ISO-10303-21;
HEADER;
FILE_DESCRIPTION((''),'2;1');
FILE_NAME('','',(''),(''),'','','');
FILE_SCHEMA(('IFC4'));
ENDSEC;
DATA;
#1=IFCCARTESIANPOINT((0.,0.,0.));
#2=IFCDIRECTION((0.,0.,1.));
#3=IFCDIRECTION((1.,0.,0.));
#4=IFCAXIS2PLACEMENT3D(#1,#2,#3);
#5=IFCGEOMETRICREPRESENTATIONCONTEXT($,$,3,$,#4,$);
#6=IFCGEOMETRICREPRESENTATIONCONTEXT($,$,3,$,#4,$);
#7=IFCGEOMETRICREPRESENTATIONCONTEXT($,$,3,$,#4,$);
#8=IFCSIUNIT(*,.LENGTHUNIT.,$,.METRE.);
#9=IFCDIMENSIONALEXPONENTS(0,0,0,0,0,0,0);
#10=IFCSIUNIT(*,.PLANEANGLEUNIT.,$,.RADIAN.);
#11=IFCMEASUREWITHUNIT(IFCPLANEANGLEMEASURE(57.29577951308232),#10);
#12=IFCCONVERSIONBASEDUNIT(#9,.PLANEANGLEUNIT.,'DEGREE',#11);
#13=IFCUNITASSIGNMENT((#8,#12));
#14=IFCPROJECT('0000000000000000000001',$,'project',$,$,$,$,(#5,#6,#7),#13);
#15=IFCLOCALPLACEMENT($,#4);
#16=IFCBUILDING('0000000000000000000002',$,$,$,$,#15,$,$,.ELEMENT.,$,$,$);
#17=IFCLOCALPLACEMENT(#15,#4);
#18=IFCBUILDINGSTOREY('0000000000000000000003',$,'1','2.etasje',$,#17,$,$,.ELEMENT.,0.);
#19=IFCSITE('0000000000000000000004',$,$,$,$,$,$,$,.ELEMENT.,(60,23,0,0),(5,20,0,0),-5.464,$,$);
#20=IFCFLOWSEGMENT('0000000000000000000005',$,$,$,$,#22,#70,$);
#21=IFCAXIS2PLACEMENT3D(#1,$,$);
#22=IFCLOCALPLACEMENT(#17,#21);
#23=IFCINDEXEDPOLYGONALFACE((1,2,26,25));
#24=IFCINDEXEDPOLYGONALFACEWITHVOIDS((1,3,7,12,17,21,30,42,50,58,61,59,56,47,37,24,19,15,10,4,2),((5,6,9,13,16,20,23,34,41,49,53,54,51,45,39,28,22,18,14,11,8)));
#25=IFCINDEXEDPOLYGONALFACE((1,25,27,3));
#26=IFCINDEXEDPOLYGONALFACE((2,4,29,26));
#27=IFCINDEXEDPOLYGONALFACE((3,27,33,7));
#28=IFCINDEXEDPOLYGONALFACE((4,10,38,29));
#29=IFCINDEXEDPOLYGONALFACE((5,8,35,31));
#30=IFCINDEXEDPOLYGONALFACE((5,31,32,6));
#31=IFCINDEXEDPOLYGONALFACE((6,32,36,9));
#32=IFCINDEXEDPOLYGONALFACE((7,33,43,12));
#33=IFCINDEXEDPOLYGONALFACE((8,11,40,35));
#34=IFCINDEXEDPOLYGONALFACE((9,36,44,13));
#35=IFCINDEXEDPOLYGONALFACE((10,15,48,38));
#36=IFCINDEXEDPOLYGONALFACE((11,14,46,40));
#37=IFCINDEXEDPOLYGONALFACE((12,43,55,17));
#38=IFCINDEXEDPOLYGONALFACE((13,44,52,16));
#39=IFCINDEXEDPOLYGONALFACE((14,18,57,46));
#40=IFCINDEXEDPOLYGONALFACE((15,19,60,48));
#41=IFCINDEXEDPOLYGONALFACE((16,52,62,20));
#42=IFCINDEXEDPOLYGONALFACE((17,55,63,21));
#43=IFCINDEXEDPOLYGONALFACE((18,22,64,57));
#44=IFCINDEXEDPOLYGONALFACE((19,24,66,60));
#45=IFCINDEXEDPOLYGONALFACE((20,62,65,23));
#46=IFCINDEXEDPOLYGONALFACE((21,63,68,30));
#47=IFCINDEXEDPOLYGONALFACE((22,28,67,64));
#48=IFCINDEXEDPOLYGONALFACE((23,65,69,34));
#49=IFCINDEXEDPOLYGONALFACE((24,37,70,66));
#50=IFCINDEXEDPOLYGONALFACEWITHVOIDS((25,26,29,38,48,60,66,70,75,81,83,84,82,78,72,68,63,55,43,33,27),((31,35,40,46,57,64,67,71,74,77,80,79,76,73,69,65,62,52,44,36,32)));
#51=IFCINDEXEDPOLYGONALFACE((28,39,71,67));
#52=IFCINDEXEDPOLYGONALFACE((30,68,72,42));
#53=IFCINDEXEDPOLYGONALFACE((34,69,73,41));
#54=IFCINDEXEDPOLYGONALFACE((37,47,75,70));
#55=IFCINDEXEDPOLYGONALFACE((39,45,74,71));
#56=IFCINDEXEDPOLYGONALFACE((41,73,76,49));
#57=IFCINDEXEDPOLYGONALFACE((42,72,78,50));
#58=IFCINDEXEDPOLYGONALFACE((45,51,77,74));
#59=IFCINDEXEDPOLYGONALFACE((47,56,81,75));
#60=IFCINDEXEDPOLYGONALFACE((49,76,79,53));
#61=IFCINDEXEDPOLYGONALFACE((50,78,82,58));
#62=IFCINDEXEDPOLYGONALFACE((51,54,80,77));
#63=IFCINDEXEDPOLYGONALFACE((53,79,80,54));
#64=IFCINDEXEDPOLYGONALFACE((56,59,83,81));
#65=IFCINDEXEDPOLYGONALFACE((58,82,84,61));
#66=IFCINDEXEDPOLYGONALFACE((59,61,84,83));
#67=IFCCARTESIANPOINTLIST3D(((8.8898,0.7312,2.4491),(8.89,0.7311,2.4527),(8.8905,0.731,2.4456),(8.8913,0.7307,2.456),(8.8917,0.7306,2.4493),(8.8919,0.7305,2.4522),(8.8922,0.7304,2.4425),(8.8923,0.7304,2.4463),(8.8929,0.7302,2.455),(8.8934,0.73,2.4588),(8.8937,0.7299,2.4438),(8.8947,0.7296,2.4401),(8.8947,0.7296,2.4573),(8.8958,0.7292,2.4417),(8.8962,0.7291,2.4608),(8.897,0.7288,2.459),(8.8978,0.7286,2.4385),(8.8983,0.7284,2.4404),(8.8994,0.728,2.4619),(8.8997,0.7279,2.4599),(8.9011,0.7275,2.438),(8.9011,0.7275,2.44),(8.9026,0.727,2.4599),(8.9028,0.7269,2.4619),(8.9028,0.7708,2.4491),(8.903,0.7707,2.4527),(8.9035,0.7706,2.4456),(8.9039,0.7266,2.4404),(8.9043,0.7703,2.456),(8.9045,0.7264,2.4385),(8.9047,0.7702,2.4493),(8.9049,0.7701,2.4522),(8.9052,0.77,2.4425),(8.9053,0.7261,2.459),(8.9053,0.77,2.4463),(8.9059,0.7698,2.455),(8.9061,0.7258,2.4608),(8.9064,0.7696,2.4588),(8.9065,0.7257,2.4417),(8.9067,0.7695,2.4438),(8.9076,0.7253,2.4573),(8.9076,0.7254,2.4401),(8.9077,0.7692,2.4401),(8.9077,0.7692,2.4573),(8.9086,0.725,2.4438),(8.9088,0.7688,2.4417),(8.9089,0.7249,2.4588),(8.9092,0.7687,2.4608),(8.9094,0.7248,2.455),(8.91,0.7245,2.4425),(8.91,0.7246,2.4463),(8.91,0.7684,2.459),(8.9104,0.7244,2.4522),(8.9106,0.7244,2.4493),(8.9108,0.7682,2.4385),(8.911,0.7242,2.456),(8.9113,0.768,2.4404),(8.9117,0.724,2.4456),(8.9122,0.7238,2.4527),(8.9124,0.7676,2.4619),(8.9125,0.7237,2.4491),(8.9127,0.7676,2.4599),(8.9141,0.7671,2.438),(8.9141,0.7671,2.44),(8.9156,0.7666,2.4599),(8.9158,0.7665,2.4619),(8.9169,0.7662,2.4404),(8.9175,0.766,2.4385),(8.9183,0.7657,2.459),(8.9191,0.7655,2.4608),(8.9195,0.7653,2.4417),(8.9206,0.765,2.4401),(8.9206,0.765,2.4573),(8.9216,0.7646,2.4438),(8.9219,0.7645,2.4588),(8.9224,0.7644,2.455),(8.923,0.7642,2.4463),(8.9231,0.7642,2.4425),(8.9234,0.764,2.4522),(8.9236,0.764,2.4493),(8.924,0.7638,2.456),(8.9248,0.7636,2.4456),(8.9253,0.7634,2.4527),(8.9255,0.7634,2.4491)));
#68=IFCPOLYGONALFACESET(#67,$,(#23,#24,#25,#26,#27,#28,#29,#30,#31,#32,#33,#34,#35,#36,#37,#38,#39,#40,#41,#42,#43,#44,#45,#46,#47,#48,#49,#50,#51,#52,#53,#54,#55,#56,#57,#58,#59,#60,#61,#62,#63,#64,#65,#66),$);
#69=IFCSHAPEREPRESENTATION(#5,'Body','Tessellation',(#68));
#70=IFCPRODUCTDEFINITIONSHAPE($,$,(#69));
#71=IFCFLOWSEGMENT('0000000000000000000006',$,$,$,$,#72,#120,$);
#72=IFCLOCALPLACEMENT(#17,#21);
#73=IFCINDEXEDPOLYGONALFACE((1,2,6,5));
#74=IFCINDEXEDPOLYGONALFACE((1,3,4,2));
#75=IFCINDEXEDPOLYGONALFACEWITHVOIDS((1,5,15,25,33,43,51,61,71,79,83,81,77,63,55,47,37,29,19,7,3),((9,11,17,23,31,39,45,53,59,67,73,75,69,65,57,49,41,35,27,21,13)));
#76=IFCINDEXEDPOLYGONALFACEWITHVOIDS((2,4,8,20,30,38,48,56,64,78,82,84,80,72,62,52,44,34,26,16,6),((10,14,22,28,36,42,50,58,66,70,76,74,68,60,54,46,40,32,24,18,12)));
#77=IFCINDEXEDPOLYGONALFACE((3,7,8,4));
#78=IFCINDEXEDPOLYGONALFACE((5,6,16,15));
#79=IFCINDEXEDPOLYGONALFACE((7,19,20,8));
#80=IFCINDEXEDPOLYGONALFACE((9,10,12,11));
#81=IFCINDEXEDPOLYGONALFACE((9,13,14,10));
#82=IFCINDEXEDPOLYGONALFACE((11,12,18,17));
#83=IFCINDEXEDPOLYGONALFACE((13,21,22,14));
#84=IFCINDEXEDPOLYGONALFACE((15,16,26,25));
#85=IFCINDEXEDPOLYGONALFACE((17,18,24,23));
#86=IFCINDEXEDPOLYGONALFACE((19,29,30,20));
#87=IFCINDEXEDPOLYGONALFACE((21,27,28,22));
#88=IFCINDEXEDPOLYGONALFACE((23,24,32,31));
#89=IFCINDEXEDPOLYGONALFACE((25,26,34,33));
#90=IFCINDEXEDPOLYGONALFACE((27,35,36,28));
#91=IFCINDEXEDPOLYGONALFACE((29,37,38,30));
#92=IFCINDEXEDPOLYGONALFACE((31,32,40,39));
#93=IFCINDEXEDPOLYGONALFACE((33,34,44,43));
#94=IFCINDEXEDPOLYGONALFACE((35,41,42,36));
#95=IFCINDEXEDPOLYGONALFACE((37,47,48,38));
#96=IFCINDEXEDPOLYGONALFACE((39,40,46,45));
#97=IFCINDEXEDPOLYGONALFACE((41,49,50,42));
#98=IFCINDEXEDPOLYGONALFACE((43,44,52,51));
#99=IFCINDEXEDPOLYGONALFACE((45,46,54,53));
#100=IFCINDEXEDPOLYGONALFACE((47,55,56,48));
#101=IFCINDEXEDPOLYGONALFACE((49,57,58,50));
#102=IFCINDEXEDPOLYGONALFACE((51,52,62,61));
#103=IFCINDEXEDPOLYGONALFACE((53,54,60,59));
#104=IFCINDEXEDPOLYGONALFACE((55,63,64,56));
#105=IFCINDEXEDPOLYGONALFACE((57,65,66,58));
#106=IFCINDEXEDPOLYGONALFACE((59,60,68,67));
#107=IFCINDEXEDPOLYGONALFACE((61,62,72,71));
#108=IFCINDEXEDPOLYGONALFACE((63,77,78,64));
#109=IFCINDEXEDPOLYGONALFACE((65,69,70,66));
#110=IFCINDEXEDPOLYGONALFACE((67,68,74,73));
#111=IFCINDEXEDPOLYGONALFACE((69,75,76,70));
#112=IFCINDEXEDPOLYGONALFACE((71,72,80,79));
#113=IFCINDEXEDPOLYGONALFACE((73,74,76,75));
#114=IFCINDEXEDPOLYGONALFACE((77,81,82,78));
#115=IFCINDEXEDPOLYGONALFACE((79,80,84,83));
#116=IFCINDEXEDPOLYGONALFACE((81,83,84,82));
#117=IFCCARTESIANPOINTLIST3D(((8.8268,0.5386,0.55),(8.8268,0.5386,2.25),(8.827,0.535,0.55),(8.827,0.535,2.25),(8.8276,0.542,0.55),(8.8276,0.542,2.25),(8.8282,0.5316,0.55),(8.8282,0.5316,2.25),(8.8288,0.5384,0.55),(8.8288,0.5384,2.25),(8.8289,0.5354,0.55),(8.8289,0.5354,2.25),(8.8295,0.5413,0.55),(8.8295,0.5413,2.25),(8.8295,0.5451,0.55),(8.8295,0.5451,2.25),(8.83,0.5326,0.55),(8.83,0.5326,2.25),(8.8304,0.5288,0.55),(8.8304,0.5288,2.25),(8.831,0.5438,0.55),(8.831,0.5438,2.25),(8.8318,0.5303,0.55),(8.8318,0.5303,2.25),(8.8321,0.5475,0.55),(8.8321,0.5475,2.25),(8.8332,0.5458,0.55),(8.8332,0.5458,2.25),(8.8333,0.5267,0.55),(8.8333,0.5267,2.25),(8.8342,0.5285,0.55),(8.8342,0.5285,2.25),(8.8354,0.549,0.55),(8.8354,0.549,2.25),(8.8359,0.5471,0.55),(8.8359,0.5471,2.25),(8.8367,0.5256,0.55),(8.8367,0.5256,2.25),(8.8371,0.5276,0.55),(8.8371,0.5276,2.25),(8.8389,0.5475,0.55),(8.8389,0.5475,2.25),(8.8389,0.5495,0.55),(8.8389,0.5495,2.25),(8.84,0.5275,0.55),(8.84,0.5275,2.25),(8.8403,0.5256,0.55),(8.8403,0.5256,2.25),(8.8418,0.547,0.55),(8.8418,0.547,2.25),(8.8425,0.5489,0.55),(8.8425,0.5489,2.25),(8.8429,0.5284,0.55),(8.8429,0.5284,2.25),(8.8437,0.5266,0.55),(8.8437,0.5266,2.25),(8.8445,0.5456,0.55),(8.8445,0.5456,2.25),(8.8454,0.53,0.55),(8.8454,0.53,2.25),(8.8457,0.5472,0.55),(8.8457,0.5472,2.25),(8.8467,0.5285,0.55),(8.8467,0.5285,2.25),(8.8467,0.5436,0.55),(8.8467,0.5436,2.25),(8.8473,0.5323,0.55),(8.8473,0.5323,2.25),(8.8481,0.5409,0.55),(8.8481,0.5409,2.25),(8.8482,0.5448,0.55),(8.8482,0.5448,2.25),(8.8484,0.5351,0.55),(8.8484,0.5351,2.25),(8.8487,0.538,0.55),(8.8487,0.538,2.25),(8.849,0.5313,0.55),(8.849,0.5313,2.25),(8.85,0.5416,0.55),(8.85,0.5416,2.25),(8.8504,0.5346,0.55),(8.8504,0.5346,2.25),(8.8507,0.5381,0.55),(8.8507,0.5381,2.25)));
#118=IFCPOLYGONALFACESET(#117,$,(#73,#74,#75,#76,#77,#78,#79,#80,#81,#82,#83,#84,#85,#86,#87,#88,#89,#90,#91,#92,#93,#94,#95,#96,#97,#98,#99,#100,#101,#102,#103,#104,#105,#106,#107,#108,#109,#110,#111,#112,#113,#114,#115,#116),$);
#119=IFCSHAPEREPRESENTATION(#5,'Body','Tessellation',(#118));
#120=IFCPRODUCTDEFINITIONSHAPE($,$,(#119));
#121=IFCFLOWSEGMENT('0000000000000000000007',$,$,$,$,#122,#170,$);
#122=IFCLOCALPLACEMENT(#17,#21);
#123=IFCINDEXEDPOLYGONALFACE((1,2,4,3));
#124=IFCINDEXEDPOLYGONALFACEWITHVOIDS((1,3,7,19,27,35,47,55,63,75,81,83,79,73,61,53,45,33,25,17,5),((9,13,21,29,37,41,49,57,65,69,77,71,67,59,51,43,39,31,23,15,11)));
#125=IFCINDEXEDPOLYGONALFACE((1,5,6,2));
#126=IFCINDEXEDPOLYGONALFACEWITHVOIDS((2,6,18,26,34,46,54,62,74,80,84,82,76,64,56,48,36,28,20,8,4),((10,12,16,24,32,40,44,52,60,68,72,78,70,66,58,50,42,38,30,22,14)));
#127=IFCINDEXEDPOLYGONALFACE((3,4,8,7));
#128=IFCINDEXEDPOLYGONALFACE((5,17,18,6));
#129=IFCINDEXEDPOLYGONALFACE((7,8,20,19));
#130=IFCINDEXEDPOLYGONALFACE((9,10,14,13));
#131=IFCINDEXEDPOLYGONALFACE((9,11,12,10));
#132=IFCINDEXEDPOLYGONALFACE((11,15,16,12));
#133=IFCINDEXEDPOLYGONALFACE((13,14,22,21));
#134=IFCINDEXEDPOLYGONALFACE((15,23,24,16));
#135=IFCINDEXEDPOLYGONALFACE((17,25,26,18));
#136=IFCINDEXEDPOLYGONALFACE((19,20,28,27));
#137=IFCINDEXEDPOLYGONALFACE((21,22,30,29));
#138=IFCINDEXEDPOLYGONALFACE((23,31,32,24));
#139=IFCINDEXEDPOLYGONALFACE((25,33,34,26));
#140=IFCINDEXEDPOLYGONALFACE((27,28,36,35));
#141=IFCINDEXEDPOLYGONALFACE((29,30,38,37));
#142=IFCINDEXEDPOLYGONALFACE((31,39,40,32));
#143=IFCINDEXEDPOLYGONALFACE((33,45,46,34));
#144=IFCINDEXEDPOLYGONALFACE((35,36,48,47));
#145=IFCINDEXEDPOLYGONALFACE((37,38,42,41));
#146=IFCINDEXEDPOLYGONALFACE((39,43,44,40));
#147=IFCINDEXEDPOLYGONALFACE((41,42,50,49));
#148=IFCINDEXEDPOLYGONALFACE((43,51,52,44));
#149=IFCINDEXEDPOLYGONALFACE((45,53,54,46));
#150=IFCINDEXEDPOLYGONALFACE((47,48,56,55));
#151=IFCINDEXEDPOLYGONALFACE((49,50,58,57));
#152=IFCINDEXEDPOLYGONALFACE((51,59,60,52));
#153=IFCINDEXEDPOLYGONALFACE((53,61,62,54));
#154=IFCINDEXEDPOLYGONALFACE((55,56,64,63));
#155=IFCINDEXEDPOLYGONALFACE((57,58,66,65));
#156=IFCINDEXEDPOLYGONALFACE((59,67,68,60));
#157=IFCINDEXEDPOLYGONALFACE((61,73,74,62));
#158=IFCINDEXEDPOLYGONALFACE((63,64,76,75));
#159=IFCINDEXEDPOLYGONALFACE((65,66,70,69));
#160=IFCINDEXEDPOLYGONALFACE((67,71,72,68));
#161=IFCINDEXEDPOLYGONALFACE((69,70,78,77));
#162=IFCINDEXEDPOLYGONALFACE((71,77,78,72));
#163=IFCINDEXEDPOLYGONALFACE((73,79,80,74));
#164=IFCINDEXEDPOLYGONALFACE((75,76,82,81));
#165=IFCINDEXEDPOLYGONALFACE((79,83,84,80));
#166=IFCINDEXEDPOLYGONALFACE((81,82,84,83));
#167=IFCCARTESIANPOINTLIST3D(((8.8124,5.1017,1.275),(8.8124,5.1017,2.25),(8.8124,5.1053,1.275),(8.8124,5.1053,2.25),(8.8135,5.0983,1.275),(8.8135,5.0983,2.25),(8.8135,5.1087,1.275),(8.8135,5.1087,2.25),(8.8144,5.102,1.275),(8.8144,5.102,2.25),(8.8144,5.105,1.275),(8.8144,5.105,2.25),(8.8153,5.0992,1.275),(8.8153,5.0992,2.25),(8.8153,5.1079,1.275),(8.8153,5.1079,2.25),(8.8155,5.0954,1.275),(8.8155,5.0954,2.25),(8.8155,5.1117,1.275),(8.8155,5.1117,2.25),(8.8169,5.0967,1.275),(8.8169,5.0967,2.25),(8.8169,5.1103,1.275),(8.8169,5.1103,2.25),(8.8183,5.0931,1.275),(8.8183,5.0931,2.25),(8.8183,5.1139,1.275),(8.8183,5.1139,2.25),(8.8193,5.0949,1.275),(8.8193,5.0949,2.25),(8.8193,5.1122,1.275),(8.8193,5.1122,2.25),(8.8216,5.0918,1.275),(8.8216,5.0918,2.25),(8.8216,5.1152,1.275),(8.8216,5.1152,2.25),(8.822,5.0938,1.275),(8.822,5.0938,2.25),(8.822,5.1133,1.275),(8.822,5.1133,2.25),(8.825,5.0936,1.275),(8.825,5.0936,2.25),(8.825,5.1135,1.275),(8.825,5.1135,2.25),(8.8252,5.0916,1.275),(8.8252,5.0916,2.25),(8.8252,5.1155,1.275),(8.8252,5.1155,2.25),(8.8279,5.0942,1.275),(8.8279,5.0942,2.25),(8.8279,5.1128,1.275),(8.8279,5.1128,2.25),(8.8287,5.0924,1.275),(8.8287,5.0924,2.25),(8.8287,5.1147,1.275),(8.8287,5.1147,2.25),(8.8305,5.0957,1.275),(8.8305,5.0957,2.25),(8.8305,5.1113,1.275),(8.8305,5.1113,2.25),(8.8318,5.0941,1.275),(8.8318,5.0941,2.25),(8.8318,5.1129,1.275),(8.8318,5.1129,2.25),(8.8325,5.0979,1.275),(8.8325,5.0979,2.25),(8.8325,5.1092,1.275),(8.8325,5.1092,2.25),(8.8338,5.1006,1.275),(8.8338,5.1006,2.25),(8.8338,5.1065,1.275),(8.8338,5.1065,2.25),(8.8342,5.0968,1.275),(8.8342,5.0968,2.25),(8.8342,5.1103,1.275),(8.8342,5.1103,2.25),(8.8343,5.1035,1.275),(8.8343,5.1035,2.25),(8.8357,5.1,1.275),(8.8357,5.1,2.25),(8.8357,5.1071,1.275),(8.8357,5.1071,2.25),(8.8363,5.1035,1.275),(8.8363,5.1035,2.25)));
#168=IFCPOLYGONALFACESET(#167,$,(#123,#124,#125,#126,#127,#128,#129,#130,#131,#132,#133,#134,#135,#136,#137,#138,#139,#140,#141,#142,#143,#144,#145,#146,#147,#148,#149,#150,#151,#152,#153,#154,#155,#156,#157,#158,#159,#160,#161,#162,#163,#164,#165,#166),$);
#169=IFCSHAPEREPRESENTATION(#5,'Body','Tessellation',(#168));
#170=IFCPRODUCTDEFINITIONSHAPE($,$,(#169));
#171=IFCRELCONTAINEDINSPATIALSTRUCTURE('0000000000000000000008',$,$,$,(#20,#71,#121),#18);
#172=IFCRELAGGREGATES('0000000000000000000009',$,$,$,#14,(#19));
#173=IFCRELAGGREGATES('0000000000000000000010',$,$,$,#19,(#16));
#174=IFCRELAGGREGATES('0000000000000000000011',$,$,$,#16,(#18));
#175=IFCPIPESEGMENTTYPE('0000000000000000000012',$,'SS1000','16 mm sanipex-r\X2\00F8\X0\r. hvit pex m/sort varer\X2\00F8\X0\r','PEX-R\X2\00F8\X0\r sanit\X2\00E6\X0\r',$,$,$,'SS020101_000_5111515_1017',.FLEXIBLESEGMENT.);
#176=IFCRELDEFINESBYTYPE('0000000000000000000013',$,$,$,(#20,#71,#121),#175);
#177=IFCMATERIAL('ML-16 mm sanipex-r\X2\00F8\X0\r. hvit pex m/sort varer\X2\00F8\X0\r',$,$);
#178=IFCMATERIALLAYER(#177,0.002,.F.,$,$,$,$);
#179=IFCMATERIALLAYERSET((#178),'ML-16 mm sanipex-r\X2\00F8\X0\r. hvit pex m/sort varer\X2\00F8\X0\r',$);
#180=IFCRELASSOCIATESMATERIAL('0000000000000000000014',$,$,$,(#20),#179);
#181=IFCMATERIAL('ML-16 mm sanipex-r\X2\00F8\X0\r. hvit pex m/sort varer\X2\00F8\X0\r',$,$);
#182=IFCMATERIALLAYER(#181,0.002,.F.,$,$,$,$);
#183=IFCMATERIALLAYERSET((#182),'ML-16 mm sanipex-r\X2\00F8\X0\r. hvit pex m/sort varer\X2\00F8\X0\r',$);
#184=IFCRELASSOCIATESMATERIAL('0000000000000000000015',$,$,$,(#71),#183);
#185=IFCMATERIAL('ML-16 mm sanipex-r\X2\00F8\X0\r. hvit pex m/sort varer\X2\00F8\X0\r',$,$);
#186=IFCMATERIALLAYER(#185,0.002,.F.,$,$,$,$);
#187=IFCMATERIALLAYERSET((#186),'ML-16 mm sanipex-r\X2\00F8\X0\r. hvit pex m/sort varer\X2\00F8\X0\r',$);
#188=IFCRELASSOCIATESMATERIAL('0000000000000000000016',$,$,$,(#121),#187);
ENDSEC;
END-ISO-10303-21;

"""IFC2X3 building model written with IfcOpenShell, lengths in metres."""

from ifc_helpers import new_model, entity, si_unit, converted_unit, frame, origin_with_axes, origin_2d_with_axis, place, context, project, spatial, hollow_circle, extrude, material, layer, layer_set, layer_usage, type_object, element, save


model = new_model("IFC2X3")

# Units and contexts
context_of_model_1 = context(None, 3, world=origin_with_axes())
context_of_model_2 = context(None, 3, world=origin_with_axes())
context_of_model_3 = context(None, 3, world=origin_with_axes())
ifc_project = project(units=[si_unit("LENGTHUNIT", "METRE"), converted_unit("PLANEANGLEUNIT", "DEGREE", entity("IfcPlaneAngleMeasure", 57.29577951308232), si_unit("PLANEANGLEUNIT", "RADIAN"), dimensions=[0, 0, 0, 0, 0, 0, 0])], contexts=[context_of_model_1, context_of_model_2, context_of_model_3])

# Site, building, storey
site = spatial("IfcSite", under=ifc_project, CompositionType="ELEMENT", RefLatitude=(60, 23, 0, 0), RefLongitude=(5, 20, 0, 0), RefElevation=-5.464)
building_placement = place(None, origin_with_axes())
building = spatial("IfcBuilding", under=site, at=building_placement, CompositionType="ELEMENT")
storey_placement = place(building_placement, origin_with_axes())
storey = spatial("IfcBuildingStorey", under=building, at=storey_placement, Name="1", Description="2.etasje", CompositionType="ELEMENT", Elevation=0.0)

# Flow segments
pipe_segment_type_1 = type_object("IfcPipeSegmentType", Name="SS1000", Description="16 mm sanipex-rør. hvit pex m/sort varerør", ApplicableOccurrence="PEX-Rør sanitær", ElementType="SS020101_000_5111515_1017", PredefinedType="FLEXIBLESEGMENT")
ifc_material_1 = material(Name="ML-16 mm sanipex-rør. hvit pex m/sort varerør")
ifc_layer_1 = layer(ifc_material_1, 0.002, ventilated=False)
ifc_layer_set_1 = layer_set([ifc_layer_1], Name="ML-16 mm sanipex-rør. hvit pex m/sort varerør")
ifc_layer_usage_1 = layer_usage(ifc_layer_set_1, "AXIS2", "POSITIVE", 0.0)
flow_segment_1_placement = place(storey_placement, frame((8.9141, 0.7671, 2.45), z_axis=(-0.312064, -0.950061, 0.0), x_axis=(0.0, 0.0, -1.0)))
element("IfcFlowSegment", 1, at=flow_segment_1_placement, inside=storey, type_object=pipe_segment_type_1, material=ifc_layer_usage_1, context=context_of_model_1, shape_type="SweptSolid", body=[
    extrude(hollow_circle(Radius=0.012, WallThickness=0.002, at=origin_2d_with_axis()), origin_with_axes(), (0.0, 0.0, 1.0), 0.0417),
])
ifc_material_2 = material(Name="ML-16 mm sanipex-rør. hvit pex m/sort varerør")
ifc_layer_2 = layer(ifc_material_2, 0.002, ventilated=False)
ifc_layer_set_2 = layer_set([ifc_layer_2], Name="ML-16 mm sanipex-rør. hvit pex m/sort varerør")
ifc_layer_usage_2 = layer_usage(ifc_layer_set_2, "AXIS2", "POSITIVE", 0.0)
flow_segment_2_placement = place(storey_placement, frame((8.8387, 0.5375, 2.25), z_axis=(0.0, 0.0, -1.0), x_axis=(0.312064, 0.950061, 0.0)))
element("IfcFlowSegment", 2, at=flow_segment_2_placement, inside=storey, type_object=pipe_segment_type_1, material=ifc_layer_usage_2, context=context_of_model_1, shape_type="SweptSolid", body=[
    extrude(hollow_circle(Radius=0.012, WallThickness=0.002, at=origin_2d_with_axis()), origin_with_axes(), (0.0, 0.0, 1.0), 1.7),
])
ifc_material_3 = material(Name="ML-16 mm sanipex-rør. hvit pex m/sort varerør")
ifc_layer_3 = layer(ifc_material_3, 0.002, ventilated=False)
ifc_layer_set_3 = layer_set([ifc_layer_3], Name="ML-16 mm sanipex-rør. hvit pex m/sort varerør")
ifc_layer_usage_3 = layer_usage(ifc_layer_set_3, "AXIS2", "POSITIVE", 0.0)
flow_segment_3_placement = place(storey_placement, frame((8.8243, 5.1035, 1.275), z_axis=(0.0, 0.0, 1.0), x_axis=(1.0, 0.0, 0.0)))
element("IfcFlowSegment", 3, at=flow_segment_3_placement, inside=storey, type_object=pipe_segment_type_1, material=ifc_layer_usage_3, context=context_of_model_1, shape_type="SweptSolid", body=[
    extrude(hollow_circle(Radius=0.012, WallThickness=0.002, at=origin_2d_with_axis()), origin_with_axes(), (0.0, 0.0, 1.0), 0.975),
])

save(model, "model.ifc")
